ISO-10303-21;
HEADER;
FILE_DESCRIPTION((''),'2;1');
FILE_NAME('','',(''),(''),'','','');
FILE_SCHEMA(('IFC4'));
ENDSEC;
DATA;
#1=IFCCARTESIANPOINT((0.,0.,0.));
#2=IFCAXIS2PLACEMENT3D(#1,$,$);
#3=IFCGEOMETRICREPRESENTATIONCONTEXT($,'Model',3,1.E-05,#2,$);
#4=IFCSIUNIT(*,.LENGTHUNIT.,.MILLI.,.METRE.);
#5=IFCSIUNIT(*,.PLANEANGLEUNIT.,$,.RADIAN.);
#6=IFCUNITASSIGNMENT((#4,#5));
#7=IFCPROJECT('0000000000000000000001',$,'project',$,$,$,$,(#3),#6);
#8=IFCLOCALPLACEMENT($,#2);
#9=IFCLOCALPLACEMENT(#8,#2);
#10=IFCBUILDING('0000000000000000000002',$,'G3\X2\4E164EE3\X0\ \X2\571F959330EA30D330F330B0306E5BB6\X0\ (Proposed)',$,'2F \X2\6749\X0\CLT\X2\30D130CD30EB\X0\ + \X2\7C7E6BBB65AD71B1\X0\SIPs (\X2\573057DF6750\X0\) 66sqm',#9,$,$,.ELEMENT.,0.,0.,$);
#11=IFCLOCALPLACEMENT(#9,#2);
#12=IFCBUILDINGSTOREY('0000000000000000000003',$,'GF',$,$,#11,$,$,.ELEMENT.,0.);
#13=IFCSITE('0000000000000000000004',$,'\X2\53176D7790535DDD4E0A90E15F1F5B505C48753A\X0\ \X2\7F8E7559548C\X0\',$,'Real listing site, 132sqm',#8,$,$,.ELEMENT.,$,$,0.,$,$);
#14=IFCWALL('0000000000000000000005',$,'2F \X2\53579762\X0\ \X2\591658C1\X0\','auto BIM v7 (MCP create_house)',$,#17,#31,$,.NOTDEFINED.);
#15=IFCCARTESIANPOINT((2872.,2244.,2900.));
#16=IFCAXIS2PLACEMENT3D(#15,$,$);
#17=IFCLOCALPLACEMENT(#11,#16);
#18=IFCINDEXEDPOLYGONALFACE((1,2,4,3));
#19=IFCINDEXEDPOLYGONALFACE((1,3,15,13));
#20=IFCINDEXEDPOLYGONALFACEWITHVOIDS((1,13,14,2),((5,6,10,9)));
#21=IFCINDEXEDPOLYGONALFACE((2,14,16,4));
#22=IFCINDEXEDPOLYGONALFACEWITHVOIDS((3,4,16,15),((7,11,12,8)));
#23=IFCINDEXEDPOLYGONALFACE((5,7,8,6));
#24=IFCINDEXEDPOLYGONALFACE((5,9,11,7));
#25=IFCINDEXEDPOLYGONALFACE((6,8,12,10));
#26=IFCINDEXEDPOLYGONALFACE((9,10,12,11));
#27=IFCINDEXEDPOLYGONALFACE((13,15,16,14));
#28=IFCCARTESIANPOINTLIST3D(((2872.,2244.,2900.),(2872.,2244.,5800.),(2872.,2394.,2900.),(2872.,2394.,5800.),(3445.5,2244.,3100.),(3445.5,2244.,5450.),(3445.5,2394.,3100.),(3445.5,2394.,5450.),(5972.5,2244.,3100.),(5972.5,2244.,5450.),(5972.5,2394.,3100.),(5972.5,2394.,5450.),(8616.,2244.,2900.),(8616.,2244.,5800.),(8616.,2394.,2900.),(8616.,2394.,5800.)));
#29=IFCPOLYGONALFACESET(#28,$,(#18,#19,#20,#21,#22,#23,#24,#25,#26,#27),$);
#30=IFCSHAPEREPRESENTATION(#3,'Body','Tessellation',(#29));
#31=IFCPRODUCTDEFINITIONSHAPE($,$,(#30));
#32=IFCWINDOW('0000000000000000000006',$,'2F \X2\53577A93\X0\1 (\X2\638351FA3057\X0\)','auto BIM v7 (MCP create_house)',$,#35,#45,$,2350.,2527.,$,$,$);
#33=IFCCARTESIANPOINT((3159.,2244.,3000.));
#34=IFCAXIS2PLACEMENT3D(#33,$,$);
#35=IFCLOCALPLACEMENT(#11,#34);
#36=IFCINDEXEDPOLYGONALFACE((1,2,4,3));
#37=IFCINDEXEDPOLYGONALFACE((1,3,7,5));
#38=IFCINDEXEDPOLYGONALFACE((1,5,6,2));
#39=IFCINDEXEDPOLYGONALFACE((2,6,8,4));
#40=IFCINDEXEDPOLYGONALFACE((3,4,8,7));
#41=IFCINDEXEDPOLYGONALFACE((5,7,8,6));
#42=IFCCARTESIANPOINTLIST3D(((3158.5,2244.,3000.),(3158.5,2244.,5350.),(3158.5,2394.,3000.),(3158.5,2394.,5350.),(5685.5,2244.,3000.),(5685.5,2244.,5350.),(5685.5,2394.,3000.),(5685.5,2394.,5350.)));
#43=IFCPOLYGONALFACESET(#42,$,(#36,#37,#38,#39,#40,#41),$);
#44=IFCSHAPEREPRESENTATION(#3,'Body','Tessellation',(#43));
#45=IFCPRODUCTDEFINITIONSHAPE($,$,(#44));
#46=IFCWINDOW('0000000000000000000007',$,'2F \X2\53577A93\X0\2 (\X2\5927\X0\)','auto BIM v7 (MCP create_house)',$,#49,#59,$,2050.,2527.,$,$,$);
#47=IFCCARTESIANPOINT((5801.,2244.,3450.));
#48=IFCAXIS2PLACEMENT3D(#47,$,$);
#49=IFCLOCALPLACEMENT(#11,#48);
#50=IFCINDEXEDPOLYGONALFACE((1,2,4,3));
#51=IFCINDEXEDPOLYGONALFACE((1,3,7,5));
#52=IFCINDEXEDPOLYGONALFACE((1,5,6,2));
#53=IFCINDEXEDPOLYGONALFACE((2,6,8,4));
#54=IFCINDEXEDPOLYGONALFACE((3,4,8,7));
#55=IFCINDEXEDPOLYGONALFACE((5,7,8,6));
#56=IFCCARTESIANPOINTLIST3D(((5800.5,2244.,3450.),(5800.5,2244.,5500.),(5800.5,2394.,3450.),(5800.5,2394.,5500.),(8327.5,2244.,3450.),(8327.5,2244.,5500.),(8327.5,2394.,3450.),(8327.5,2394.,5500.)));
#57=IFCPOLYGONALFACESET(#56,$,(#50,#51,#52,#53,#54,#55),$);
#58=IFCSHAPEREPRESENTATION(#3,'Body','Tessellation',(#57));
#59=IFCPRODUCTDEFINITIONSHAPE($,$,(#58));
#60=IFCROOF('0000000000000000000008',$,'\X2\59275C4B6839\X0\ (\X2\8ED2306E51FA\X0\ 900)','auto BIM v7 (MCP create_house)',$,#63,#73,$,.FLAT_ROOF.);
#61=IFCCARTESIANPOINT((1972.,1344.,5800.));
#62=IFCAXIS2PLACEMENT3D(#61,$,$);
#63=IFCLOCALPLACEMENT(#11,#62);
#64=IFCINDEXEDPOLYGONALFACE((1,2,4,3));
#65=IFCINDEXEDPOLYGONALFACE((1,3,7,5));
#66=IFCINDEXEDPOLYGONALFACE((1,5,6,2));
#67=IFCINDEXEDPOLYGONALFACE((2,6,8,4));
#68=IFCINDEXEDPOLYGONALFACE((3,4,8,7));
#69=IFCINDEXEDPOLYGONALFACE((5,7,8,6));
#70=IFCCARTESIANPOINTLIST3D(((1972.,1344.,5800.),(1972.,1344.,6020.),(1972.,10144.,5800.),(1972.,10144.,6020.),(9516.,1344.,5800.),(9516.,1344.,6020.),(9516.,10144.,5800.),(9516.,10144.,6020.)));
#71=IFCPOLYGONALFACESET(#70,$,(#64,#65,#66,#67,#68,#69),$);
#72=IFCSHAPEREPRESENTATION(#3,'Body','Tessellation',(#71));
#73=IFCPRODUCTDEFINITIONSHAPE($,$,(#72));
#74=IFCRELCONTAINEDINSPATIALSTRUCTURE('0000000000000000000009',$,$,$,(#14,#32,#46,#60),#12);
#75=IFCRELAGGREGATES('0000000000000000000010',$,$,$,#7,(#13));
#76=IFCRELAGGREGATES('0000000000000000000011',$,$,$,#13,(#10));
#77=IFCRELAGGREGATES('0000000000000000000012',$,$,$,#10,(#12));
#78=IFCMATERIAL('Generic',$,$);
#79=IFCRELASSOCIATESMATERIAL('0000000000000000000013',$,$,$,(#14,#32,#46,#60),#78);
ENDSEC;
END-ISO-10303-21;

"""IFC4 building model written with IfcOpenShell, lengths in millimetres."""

from ifc_helpers import new_model, si_unit, frame, frame_2d, origin, place, context, project, spatial, rectangle, extrude, material, element, fill, save


model = new_model("IFC4")

# Units and contexts
model_context = context("Model", 3, precision=1e-05, world=origin())
ifc_project = project(units=[si_unit("LENGTHUNIT", "METRE", prefix="MILLI"), si_unit("PLANEANGLEUNIT", "RADIAN")], contexts=[model_context])

# Site, building, storey
site_placement = place(None, origin())
site = spatial("IfcSite", under=ifc_project, at=site_placement, Name="北海道川上郡弟子屈町 美留和", ObjectType="Real listing site, 132sqm", CompositionType="ELEMENT", RefElevation=0.0)
building_placement = place(site_placement, origin())
building = spatial("IfcBuilding", under=site, at=building_placement, Name="G3世代 土間リビングの家 (Proposed)", ObjectType="2F 杉CLTパネル + 籾殻断熱SIPs (地域材) 66sqm", CompositionType="ELEMENT", ElevationOfRefHeight=0.0, ElevationOfTerrain=0.0)
storey_placement = place(building_placement, origin())
storey = spatial("IfcBuildingStorey", under=building, at=storey_placement, Name="GF", CompositionType="ELEMENT", Elevation=0.0)

# Shared definitions
ifc_material = material(Name="Generic")

# Wall, openings, windows
wall_1_placement = place(storey_placement, frame((2872.0, 2244.0, 2900.0)))
wall_1 = element("IfcWall", 1, at=wall_1_placement, inside=storey, material=ifc_material, Name="2F 南面 外壁", Description="auto BIM v7 (MCP create_house)", PredefinedType="NOTDEFINED", context=model_context, shape_type="SweptSolid", body=[
    extrude(rectangle(XDim=5744.0, YDim=150.0, at=frame_2d((2872.0, 75.0))), frame((2872.0, 2244.0, 2900.0)), (0.0, 0.0, 1.0), 2900.0),
])
opening_1_placement = place(storey_placement, frame((3159.0, 2244.0, 3000.0)))
opening_1 = element("IfcOpeningElement", 2, at=opening_1_placement, cuts=wall_1, PredefinedType="NOTDEFINED", context=model_context, shape_type="SweptSolid", body=[
    extrude(rectangle(XDim=2527.0, YDim=150.0, at=frame_2d((1263.0, 75.0))), frame((3159.0, 2244.0, 3000.0)), (0.0, 0.0, 1.0), 2350.0),
])
opening_2_placement = place(storey_placement, frame((5801.0, 2244.0, 3450.0)))
opening_2 = element("IfcOpeningElement", 3, at=opening_2_placement, cuts=wall_1, PredefinedType="NOTDEFINED", context=model_context, shape_type="SweptSolid", body=[
    extrude(rectangle(XDim=2527.0, YDim=150.0, at=frame_2d((1263.0, 75.0))), frame((5801.0, 2244.0, 3450.0)), (0.0, 0.0, 1.0), 2050.0),
])
window_1_placement = place(storey_placement, frame((3159.0, 2244.0, 3000.0)))
window_1 = element("IfcWindow", 4, at=window_1_placement, inside=storey, material=ifc_material, Name="2F 南窓1 (掃出し)", Description="auto BIM v7 (MCP create_house)", OverallHeight=2350.0, OverallWidth=2527.0, context=model_context, shape_type="SweptSolid", body=[
    extrude(rectangle(XDim=2527.0, YDim=150.0, at=frame_2d((1263.0, 75.0))), frame((3159.0, 2244.0, 3000.0)), (0.0, 0.0, 1.0), 2350.0),
])
fill(opening_1, window_1)
window_2_placement = place(storey_placement, frame((5801.0, 2244.0, 3450.0)))
window_2 = element("IfcWindow", 5, at=window_2_placement, inside=storey, material=ifc_material, Name="2F 南窓2 (大)", Description="auto BIM v7 (MCP create_house)", OverallHeight=2050.0, OverallWidth=2527.0, context=model_context, shape_type="SweptSolid", body=[
    extrude(rectangle(XDim=2527.0, YDim=150.0, at=frame_2d((1263.0, 75.0))), frame((5801.0, 2244.0, 3450.0)), (0.0, 0.0, 1.0), 2050.0),
])
fill(opening_2, window_2)

# Roof
roof_placement = place(storey_placement, frame((1972.0, 1344.0, 5800.0)))
element("IfcRoof", 6, at=roof_placement, inside=storey, material=ifc_material, Name="大屋根 (軒の出 900)", Description="auto BIM v7 (MCP create_house)", PredefinedType="FLAT_ROOF", context=model_context, shape_type="SweptSolid", body=[
    extrude(rectangle(XDim=7544.0, YDim=8800.0, at=frame_2d((3772.0, 4400.0))), frame((1972.0, 1344.0, 5800.0)), (0.0, 0.0, 1.0), 220.0),
])

save(model, "model.ifc")
